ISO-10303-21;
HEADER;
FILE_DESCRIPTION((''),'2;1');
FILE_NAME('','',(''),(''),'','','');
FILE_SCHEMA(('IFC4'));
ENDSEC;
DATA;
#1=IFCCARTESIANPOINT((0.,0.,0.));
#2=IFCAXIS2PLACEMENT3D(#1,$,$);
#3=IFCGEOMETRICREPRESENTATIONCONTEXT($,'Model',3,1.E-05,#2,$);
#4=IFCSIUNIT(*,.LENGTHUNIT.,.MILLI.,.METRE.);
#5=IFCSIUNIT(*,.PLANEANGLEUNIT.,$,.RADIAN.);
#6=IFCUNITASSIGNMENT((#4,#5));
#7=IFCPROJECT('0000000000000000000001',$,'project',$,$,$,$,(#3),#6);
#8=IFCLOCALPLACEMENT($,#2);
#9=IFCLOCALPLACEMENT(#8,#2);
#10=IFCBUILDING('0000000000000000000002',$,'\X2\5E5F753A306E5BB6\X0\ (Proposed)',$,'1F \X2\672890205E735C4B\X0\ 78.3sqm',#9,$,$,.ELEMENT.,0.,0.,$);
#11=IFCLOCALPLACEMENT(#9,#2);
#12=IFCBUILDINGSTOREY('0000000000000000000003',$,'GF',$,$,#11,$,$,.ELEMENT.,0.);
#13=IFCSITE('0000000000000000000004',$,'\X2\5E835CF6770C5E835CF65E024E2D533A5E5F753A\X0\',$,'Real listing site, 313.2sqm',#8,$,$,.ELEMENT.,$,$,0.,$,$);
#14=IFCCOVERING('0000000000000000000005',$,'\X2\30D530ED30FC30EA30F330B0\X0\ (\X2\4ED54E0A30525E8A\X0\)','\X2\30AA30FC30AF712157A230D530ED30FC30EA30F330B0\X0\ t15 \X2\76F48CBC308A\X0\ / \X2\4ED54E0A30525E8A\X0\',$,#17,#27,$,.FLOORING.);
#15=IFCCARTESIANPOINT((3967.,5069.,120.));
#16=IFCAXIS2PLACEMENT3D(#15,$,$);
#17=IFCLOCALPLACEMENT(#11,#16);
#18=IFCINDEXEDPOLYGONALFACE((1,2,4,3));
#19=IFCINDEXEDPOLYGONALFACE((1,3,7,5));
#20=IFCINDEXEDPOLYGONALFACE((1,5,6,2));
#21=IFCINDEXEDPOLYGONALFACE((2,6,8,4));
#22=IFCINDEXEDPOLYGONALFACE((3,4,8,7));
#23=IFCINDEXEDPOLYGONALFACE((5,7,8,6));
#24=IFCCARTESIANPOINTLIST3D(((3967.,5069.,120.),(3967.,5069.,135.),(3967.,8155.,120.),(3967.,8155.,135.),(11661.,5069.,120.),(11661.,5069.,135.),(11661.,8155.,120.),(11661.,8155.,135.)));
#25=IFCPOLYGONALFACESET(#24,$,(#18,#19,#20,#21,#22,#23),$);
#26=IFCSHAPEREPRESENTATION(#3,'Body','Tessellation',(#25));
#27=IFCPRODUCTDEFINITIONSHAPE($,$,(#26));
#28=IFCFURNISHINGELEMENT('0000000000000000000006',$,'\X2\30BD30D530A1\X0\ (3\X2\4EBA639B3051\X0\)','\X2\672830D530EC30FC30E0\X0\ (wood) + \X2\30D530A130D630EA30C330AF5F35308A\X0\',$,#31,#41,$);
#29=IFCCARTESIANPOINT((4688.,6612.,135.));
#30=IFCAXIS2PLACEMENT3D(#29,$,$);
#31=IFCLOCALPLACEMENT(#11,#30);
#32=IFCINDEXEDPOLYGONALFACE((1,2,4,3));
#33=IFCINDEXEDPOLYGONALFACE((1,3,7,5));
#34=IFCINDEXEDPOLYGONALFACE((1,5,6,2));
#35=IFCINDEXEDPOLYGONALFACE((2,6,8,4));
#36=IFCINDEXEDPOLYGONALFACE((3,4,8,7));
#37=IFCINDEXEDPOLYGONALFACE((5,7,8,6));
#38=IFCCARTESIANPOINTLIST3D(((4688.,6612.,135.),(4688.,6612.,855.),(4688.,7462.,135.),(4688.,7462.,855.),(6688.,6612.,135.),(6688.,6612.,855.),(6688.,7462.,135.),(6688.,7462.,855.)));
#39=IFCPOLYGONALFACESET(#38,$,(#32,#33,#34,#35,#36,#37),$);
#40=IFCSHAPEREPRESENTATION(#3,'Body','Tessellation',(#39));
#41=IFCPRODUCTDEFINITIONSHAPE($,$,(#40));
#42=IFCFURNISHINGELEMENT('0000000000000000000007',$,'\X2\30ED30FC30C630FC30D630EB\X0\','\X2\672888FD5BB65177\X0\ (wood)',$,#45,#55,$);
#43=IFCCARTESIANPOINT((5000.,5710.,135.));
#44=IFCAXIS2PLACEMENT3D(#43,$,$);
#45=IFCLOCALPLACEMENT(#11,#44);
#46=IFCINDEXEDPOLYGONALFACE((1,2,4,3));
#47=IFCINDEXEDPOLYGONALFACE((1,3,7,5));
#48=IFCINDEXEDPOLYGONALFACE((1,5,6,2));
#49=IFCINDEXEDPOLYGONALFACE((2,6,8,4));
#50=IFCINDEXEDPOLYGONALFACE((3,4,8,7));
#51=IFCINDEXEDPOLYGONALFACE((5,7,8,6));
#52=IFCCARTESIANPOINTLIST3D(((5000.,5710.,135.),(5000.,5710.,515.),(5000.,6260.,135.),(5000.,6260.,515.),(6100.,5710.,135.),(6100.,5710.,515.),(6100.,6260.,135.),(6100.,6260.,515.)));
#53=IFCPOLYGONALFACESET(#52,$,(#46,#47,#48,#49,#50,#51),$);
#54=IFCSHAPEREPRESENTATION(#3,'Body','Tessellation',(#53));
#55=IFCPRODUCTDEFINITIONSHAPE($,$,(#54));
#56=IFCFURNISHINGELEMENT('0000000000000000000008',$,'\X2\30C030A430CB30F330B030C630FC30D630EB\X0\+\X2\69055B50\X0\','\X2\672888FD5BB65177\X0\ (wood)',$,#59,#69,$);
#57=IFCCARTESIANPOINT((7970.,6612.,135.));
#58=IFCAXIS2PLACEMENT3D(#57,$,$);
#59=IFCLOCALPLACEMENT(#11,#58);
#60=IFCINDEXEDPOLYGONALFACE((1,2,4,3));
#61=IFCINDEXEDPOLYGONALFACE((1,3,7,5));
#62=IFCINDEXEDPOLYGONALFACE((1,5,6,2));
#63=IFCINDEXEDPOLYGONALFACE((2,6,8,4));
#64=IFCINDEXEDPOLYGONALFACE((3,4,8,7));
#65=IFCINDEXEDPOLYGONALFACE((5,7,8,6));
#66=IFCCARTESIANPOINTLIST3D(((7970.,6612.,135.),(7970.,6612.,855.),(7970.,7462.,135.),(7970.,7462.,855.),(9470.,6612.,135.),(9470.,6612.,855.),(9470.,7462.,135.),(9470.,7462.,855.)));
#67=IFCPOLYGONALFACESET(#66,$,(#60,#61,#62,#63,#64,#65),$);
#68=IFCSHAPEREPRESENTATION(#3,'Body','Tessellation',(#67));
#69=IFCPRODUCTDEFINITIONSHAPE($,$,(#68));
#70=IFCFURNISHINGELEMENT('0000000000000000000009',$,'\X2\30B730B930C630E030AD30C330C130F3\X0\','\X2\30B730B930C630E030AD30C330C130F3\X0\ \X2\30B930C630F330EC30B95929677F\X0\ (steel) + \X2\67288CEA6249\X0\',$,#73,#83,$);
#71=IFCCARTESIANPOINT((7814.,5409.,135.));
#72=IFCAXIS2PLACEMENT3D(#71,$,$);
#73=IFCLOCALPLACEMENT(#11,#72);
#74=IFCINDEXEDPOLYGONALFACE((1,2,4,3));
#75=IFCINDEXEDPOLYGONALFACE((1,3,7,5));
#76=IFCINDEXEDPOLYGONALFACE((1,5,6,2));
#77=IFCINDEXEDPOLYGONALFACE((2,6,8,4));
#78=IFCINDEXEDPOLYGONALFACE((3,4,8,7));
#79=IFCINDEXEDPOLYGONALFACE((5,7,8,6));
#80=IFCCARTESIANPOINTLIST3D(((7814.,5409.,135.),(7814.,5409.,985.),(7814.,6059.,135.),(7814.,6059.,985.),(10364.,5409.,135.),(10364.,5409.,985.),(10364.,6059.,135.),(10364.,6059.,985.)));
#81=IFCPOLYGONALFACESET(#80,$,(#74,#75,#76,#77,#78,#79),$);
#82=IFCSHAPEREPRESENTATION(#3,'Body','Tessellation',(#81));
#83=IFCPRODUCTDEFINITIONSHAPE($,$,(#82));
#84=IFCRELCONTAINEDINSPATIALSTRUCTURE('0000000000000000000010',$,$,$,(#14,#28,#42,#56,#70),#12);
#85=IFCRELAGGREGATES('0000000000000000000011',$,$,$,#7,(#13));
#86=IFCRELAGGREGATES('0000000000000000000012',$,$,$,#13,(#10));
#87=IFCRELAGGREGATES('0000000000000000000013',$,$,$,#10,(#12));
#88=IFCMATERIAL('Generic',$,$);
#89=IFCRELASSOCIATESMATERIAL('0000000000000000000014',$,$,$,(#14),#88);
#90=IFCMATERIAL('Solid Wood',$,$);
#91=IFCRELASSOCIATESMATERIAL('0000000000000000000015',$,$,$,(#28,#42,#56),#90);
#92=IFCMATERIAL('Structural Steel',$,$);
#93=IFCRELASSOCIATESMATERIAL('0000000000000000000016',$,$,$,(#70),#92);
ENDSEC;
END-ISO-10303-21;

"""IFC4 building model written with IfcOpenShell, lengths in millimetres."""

from ifc_helpers import new_model, si_unit, frame, frame_2d, origin, place, context, project, spatial, rectangle, extrude, material, element, save


model = new_model("IFC4")

# Units and contexts
model_context = context("Model", 3, precision=1e-05, world=origin())
ifc_project = project(units=[si_unit("LENGTHUNIT", "METRE", prefix="MILLI"), si_unit("PLANEANGLEUNIT", "RADIAN")], contexts=[model_context])

# Site, building, storey
site_placement = place(None, origin())
site = spatial("IfcSite", under=ifc_project, at=site_placement, Name="広島県広島市中区幟町", ObjectType="Real listing site, 313.2sqm", CompositionType="ELEMENT", RefElevation=0.0)
building_placement = place(site_placement, origin())
building = spatial("IfcBuilding", under=site, at=building_placement, Name="幟町の家 (Proposed)", ObjectType="1F 木造平屋 78.3sqm", CompositionType="ELEMENT", ElevationOfRefHeight=0.0, ElevationOfTerrain=0.0)
storey_placement = place(building_placement, origin())
storey = spatial("IfcBuildingStorey", under=building, at=storey_placement, Name="GF", CompositionType="ELEMENT", Elevation=0.0)

# Shared definitions
ifc_material_1 = material(Name="Solid Wood")

# Shared definitions
ifc_material_2 = material(Name="Structural Steel")

# Covering
ifc_material_3 = material(Name="Generic")
covering_placement = place(storey_placement, frame((3967.0, 5069.0, 120.0)))
element("IfcCovering", 1, at=covering_placement, inside=storey, material=ifc_material_3, Name="フローリング (仕上げ床)", Description="オーク無垢フローリング t15 直貼り / 仕上げ床", PredefinedType="FLOORING", context=model_context, shape_type="SweptSolid", body=[
    extrude(rectangle(XDim=7694.0, YDim=3086.0, at=frame_2d((3847.0, 1543.0))), frame((3967.0, 5069.0, 120.0)), (0.0, 0.0, 1.0), 15.0),
])

# Furnishing elements
furnishing_1_placement = place(storey_placement, frame((4688.0, 6612.0, 135.0)))
element("IfcFurnishingElement", 2, at=furnishing_1_placement, inside=storey, material=ifc_material_1, Name="ソファ (3人掛け)", Description="木フレーム (wood) + ファブリック張り", context=model_context, shape_type="SweptSolid", body=[
    extrude(rectangle(XDim=2000.0, YDim=850.0, at=frame_2d((1000.0, 425.0))), frame((4688.0, 6612.0, 135.0)), (0.0, 0.0, 1.0), 720.0),
])
furnishing_2_placement = place(storey_placement, frame((5000.0, 5710.0, 135.0)))
element("IfcFurnishingElement", 3, at=furnishing_2_placement, inside=storey, material=ifc_material_1, Name="ローテーブル", Description="木製家具 (wood)", context=model_context, shape_type="SweptSolid", body=[
    extrude(rectangle(XDim=1100.0, YDim=550.0, at=frame_2d((550.0, 275.0))), frame((5000.0, 5710.0, 135.0)), (0.0, 0.0, 1.0), 380.0),
])
furnishing_3_placement = place(storey_placement, frame((7970.0, 6612.0, 135.0)))
element("IfcFurnishingElement", 4, at=furnishing_3_placement, inside=storey, material=ifc_material_1, Name="ダイニングテーブル+椅子", Description="木製家具 (wood)", context=model_context, shape_type="SweptSolid", body=[
    extrude(rectangle(XDim=1500.0, YDim=850.0, at=frame_2d((750.0, 425.0))), frame((7970.0, 6612.0, 135.0)), (0.0, 0.0, 1.0), 720.0),
])
furnishing_4_placement = place(storey_placement, frame((7814.0, 5409.0, 135.0)))
element("IfcFurnishingElement", 5, at=furnishing_4_placement, inside=storey, material=ifc_material_2, Name="システムキッチン", Description="システムキッチン ステンレス天板 (steel) + 木質扉", context=model_context, shape_type="SweptSolid", body=[
    extrude(rectangle(XDim=2550.0, YDim=650.0, at=frame_2d((1275.0, 325.0))), frame((7814.0, 5409.0, 135.0)), (0.0, 0.0, 1.0), 850.0),
])

save(model, "model.ifc")
